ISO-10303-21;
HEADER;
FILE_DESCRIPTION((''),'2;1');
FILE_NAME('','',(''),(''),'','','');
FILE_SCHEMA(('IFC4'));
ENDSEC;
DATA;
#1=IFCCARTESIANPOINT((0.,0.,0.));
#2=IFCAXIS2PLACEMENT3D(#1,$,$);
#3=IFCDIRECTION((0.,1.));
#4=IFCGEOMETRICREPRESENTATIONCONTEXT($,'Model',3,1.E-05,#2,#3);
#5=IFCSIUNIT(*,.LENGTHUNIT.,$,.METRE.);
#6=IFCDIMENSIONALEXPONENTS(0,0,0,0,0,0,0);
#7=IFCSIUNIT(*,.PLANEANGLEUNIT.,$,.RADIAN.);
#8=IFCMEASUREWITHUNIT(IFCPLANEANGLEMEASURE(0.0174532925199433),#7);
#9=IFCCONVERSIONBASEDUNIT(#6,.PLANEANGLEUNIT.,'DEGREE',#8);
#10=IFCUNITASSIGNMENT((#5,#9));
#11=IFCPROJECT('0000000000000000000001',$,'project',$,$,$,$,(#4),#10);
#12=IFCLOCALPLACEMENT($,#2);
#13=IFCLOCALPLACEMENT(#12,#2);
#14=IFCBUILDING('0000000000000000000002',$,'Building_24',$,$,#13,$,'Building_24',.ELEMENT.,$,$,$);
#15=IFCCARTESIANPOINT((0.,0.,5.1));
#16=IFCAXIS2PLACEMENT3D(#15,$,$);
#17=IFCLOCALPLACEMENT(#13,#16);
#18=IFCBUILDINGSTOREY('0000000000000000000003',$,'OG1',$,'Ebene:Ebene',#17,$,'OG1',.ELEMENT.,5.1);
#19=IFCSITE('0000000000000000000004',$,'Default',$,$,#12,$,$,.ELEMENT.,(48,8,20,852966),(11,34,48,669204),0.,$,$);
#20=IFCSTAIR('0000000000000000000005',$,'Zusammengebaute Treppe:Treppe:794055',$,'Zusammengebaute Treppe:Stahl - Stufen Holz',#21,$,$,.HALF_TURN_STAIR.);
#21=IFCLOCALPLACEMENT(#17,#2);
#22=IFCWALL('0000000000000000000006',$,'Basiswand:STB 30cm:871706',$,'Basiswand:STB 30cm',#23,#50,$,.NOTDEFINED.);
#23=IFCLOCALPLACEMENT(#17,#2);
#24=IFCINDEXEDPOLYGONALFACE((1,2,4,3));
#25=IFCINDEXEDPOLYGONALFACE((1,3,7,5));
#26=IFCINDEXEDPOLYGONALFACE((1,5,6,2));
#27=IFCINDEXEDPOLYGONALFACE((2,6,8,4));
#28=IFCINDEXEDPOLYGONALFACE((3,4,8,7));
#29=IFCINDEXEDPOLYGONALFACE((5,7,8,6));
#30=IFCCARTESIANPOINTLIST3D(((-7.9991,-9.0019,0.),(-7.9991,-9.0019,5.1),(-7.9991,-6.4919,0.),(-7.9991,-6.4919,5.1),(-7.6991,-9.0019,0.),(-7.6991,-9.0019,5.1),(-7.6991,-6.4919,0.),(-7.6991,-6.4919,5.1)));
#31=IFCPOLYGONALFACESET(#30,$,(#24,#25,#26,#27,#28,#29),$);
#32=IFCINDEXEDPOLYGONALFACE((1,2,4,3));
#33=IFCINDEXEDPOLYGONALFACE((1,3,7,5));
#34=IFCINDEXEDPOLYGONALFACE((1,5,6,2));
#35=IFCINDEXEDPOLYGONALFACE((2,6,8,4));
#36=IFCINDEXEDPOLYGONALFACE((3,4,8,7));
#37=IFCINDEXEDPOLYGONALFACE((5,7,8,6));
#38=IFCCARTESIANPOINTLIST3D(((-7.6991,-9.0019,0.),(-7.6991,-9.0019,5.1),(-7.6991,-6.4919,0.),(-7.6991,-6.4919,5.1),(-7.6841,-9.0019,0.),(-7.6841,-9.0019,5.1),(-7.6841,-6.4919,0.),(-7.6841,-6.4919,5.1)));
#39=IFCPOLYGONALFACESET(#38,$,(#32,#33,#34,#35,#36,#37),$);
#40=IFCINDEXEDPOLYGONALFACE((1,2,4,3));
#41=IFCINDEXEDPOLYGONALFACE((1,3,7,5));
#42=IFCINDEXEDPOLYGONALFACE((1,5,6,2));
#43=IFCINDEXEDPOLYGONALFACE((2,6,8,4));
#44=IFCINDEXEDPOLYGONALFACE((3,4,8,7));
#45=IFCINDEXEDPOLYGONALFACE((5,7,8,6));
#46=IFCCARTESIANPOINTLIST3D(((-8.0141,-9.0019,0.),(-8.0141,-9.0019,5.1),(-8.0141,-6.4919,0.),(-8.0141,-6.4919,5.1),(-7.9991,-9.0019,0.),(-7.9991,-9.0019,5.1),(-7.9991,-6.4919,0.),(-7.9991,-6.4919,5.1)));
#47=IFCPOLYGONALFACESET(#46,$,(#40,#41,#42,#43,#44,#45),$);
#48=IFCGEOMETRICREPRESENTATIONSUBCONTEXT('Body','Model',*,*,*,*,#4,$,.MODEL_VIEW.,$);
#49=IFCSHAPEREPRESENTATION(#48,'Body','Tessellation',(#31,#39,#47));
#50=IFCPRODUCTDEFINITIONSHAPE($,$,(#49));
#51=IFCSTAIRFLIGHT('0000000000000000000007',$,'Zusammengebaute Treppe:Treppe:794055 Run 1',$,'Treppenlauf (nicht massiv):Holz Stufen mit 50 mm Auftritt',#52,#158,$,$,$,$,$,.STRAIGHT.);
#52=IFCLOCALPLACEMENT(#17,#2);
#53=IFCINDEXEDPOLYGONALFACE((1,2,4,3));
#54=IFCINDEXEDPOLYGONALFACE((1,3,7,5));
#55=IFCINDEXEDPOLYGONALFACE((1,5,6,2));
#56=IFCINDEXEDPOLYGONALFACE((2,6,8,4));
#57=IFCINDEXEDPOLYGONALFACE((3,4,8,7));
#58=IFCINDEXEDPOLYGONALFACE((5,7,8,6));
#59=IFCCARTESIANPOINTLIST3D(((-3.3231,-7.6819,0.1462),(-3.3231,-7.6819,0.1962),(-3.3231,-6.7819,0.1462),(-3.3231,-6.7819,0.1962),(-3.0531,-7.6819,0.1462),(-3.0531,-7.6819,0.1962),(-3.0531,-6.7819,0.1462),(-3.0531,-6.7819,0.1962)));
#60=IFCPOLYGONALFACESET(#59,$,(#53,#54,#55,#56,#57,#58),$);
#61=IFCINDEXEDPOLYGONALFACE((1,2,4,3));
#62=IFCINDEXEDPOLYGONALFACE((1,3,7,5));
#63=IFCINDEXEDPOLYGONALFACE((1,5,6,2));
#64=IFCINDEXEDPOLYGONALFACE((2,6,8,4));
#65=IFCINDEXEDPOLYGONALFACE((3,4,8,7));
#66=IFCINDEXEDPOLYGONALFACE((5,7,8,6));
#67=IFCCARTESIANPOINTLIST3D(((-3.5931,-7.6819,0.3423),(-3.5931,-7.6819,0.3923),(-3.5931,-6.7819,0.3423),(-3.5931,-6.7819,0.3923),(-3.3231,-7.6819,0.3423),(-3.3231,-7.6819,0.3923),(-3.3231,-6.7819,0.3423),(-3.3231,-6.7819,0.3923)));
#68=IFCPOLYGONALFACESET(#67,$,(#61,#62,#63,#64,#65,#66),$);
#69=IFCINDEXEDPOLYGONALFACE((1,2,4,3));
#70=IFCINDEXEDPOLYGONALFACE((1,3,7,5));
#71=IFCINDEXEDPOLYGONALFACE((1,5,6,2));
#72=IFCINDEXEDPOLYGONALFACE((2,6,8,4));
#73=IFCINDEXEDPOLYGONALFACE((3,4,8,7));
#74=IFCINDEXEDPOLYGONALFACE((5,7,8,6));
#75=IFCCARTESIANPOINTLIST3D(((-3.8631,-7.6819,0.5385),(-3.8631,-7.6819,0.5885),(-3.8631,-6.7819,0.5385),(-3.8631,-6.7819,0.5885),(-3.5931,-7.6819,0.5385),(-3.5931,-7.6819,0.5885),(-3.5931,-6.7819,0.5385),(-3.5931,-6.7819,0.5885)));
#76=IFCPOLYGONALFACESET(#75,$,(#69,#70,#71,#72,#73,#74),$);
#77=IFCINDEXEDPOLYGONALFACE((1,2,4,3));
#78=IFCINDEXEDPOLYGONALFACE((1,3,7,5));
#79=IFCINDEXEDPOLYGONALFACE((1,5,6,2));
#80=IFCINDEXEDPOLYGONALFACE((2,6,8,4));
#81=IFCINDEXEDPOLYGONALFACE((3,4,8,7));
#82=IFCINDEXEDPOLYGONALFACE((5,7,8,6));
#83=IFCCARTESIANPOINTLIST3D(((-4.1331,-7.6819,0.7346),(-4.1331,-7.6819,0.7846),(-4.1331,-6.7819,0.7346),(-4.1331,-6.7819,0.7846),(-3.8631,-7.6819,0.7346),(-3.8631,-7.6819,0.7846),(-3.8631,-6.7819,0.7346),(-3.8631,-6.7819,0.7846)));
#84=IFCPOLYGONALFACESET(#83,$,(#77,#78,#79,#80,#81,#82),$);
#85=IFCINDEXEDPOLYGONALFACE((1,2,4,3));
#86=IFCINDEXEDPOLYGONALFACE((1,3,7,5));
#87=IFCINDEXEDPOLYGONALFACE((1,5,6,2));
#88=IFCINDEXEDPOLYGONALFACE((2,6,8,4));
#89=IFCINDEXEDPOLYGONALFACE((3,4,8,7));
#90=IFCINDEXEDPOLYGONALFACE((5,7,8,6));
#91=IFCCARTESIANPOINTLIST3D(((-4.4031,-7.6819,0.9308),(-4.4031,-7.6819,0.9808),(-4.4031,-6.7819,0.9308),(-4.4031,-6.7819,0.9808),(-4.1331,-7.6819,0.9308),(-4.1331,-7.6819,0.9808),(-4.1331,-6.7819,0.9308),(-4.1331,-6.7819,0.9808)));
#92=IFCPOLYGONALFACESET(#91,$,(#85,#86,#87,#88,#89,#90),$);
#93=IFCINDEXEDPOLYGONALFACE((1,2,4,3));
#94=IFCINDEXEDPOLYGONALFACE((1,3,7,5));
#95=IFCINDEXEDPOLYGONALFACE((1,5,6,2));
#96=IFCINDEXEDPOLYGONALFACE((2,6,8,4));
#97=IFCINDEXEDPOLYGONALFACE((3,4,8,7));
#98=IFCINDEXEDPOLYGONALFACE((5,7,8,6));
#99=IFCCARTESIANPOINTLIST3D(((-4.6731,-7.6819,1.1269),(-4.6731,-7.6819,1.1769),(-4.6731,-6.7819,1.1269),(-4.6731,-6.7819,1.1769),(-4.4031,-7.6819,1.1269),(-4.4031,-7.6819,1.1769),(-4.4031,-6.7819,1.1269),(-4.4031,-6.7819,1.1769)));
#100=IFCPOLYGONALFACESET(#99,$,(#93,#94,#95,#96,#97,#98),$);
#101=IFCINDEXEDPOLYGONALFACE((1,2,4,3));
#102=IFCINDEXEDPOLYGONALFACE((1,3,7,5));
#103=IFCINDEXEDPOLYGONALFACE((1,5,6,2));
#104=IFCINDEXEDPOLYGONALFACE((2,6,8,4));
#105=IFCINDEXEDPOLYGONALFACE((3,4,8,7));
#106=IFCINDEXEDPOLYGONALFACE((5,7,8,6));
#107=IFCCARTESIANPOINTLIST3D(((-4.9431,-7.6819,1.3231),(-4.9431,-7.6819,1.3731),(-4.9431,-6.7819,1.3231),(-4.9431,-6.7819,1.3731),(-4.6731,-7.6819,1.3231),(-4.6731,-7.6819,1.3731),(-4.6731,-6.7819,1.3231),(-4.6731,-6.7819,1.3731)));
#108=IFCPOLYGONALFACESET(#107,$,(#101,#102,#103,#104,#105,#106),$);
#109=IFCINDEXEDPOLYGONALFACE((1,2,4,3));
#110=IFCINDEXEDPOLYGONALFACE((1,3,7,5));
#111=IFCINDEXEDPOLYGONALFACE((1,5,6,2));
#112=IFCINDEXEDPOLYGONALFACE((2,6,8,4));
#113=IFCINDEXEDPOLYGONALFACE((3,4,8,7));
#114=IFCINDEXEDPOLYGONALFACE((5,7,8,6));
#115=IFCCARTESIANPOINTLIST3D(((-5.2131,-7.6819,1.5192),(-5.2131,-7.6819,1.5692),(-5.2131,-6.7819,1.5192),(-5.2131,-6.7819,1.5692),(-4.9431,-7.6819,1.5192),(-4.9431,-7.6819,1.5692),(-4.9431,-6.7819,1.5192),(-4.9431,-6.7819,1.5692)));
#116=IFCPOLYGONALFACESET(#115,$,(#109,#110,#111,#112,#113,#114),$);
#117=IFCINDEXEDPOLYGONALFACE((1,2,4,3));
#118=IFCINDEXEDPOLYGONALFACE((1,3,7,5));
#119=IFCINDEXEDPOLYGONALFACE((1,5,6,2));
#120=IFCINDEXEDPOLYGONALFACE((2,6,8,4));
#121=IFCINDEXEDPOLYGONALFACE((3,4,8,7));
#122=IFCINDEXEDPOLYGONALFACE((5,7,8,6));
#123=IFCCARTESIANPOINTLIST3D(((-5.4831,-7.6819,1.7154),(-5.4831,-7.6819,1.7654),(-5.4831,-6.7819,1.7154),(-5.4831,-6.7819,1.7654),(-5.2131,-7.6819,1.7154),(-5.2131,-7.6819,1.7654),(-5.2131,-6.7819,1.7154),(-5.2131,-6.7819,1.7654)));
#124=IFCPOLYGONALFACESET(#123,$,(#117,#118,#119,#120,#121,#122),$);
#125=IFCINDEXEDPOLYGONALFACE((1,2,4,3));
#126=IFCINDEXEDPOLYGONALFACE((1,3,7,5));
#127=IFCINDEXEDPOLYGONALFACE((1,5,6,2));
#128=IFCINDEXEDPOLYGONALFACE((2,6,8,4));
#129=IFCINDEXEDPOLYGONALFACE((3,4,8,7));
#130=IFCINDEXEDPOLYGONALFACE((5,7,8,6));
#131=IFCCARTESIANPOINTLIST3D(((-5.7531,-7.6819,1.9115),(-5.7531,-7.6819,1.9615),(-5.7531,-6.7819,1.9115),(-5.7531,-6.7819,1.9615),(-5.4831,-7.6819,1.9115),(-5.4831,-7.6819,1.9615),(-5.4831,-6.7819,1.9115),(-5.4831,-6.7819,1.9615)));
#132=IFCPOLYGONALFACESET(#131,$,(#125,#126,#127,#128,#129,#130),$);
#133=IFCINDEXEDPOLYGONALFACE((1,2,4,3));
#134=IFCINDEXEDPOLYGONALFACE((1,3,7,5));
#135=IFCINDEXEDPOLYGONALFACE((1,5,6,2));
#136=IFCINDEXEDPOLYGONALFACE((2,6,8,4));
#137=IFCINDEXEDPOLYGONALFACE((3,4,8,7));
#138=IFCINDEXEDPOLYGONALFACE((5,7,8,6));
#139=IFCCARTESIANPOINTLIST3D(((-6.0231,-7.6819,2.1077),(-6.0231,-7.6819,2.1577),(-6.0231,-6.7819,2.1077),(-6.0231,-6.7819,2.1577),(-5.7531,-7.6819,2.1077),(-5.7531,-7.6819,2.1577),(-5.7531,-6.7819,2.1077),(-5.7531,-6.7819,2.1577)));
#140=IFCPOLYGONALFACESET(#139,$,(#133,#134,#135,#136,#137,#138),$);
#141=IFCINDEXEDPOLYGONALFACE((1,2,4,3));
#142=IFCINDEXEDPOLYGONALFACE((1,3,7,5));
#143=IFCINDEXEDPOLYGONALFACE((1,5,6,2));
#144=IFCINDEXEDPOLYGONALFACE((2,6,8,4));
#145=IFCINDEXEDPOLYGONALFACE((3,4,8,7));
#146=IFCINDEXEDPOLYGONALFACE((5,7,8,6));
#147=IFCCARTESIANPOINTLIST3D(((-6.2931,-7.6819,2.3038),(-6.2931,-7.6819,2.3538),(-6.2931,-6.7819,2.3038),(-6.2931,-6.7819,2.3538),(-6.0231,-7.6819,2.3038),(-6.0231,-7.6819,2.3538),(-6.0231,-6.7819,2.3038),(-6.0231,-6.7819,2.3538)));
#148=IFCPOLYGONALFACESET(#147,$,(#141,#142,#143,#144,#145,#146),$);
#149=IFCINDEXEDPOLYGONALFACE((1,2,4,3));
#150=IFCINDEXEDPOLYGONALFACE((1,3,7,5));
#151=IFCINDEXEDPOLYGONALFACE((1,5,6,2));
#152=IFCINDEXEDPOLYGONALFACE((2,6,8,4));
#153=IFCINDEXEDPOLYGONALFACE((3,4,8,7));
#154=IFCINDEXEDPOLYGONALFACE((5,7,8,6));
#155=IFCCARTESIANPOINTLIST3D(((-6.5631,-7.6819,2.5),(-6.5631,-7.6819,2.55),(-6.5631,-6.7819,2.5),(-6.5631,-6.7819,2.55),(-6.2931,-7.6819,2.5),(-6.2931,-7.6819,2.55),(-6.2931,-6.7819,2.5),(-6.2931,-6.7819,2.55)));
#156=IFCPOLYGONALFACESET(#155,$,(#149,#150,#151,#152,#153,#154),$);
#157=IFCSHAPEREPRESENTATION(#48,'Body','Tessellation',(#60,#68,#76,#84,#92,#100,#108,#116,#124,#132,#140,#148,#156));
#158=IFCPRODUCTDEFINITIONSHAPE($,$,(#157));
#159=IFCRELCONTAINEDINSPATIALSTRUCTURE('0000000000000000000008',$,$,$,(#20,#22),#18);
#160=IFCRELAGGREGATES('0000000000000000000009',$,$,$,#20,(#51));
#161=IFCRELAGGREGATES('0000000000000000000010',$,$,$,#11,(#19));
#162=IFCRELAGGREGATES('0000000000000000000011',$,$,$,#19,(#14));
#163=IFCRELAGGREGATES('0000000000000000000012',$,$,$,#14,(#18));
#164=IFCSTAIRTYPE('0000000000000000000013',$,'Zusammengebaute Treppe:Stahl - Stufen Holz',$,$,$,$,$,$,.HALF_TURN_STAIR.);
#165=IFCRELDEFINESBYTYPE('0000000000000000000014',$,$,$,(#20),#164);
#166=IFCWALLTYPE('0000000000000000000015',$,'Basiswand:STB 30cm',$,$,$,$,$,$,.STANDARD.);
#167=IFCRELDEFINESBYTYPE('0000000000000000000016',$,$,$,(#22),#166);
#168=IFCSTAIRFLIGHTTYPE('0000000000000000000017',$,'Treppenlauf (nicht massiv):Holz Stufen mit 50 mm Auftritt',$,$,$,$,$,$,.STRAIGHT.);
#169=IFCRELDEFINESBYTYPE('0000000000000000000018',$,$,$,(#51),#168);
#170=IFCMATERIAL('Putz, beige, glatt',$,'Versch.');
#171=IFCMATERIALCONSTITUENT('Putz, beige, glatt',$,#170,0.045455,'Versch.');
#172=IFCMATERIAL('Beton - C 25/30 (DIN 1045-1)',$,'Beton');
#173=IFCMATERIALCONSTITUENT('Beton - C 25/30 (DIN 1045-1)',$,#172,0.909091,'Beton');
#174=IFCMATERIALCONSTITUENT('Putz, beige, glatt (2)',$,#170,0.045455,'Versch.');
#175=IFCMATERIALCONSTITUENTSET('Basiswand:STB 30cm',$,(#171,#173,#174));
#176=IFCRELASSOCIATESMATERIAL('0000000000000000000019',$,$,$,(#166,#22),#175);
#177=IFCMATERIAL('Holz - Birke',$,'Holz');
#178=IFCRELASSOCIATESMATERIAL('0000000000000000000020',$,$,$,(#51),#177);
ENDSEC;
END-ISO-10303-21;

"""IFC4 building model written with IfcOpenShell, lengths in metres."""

from ifc_helpers import new_model, entity, si_unit, converted_unit, direction, frame, origin, place, context, subcontext, project, spatial, indexed_curve, outline, extrude, material, constituent, constituent_set, type_object, element, aggregate, save


model = new_model("IFC4")

# Units and contexts
model_context = context("Model", 3, precision=1e-05, world=origin(), true_north=direction((0.0, 1.0)))
body_context = subcontext(model_context, "Body", "Model", "MODEL_VIEW")
ifc_project = project(units=[si_unit("LENGTHUNIT", "METRE"), converted_unit("PLANEANGLEUNIT", "DEGREE", entity("IfcPlaneAngleMeasure", 0.0174532925199433), si_unit("PLANEANGLEUNIT", "RADIAN"), dimensions=[0, 0, 0, 0, 0, 0, 0])], contexts=[model_context])

# Site, building, storey
site_placement = place(None, origin())
site = spatial("IfcSite", under=ifc_project, at=site_placement, Name="Default", CompositionType="ELEMENT", RefLatitude=(48, 8, 20, 852966), RefLongitude=(11, 34, 48, 669204), RefElevation=0.0)
building_placement = place(site_placement, origin())
building = spatial("IfcBuilding", under=site, at=building_placement, Name="Building_24", LongName="Building_24", CompositionType="ELEMENT")
storey_placement = place(building_placement, frame((0.0, 0.0, 5.1)))
storey = spatial("IfcBuildingStorey", under=building, at=storey_placement, Name="OG1", ObjectType="Ebene:Ebene", LongName="OG1", CompositionType="ELEMENT", Elevation=5.1)

# Stair
stair_type = type_object("IfcStairType", Name="Zusammengebaute Treppe:Stahl - Stufen Holz", PredefinedType="HALF_TURN_STAIR")
stair_placement = place(storey_placement, origin())
stair = element("IfcStair", 1, at=stair_placement, inside=storey, type_object=stair_type, Name="Zusammengebaute Treppe:Treppe:794055", ObjectType="Zusammengebaute Treppe:Stahl - Stufen Holz", PredefinedType="HALF_TURN_STAIR")
ifc_material_1 = material(Name="Holz - Birke", Category="Holz")

# Shared definitions
ifc_material_2 = material(Name="Putz, beige, glatt", Category="Versch.")
ifc_material_3 = material(Name="Beton - C 25/30 (DIN 1045-1)", Category="Beton")

# Wall
ifc_constituent_1 = constituent(ifc_material_2, Name="Putz, beige, glatt", Category="Versch.", fraction=0.045455)
ifc_constituent_2 = constituent(ifc_material_3, Name="Beton - C 25/30 (DIN 1045-1)", Category="Beton", fraction=0.909091)
ifc_constituent_3 = constituent(ifc_material_2, Name="Putz, beige, glatt (2)", Category="Versch.", fraction=0.045455)
ifc_constituent_set_1 = constituent_set(constituents=[ifc_constituent_1, ifc_constituent_2, ifc_constituent_3], Name="Basiswand:STB 30cm")
wall_type_1 = type_object("IfcWallType", Name="Basiswand:STB 30cm", PredefinedType="STANDARD", material=ifc_constituent_set_1)
wall_1_placement = place(storey_placement, frame((-7.8491, -6.4919, 0.0), z_axis=(0.0, 0.0, 1.0), x_axis=(0.0, -1.0, 0.0)))
element("IfcWall", 2, at=wall_1_placement, inside=storey, type_object=wall_type_1, material=ifc_constituent_set_1, Name="Basiswand:STB 30cm:871706", ObjectType="Basiswand:STB 30cm", PredefinedType="NOTDEFINED", context=body_context, shape_type="SweptSolid", body=[
    extrude(outline(indexed_curve([(-1.255, -0.15), (1.255, -0.15), (1.255, 0.15), (-1.255, 0.15), (-1.255, -0.15)], self_intersect=False)), frame((1.255, 0.0, 0.0)), (0.0, 0.0, 1.0), 5.1),
    extrude(outline(indexed_curve([(-0.0075, -1.255), (0.0075, -1.255), (0.0075, 1.255), (-0.0075, 1.255), (-0.0075, -1.255)], self_intersect=False)), frame((1.255, 0.1575, 0.0), z_axis=(0.0, 0.0, 1.0), x_axis=(0.0, -1.0, 0.0)), (0.0, 0.0, 1.0), 5.1),
    extrude(outline(indexed_curve([(-0.0075, -1.255), (0.0075, -1.255), (0.0075, 1.255), (-0.0075, 1.255), (-0.0075, -1.255)], self_intersect=False)), frame((1.255, -0.1575, 0.0), z_axis=(0.0, 0.0, 1.0), x_axis=(0.0, 1.0, 0.0)), (0.0, 0.0, 1.0), 5.1),
])

# Stair flight
stair_flight_type = type_object("IfcStairFlightType", Name="Treppenlauf (nicht massiv):Holz Stufen mit 50 mm Auftritt", PredefinedType="STRAIGHT")
stair_flight_1_placement = place(stair_placement, origin())
stair_flight_1 = element("IfcStairFlight", 3, at=stair_flight_1_placement, type_object=stair_flight_type, material=ifc_material_1, Name="Zusammengebaute Treppe:Treppe:794055 Run 1", ObjectType="Treppenlauf (nicht massiv):Holz Stufen mit 50 mm Auftritt", PredefinedType="STRAIGHT", context=body_context, shape_type="SweptSolid", body=[
    extrude(outline(indexed_curve([(-0.135, -0.45), (0.135, -0.45), (0.135, 0.45), (-0.135, 0.45), (-0.135, -0.45)], self_intersect=False)), frame((-3.1881, -7.2319, 0.1462)), (0.0, 0.0, 1.0), 0.05),
    extrude(outline(indexed_curve([(-0.135, -0.45), (0.135, -0.45), (0.135, 0.45), (-0.135, 0.45), (-0.135, -0.45)], self_intersect=False)), frame((-3.4581, -7.2319, 0.3423)), (0.0, 0.0, 1.0), 0.05),
    extrude(outline(indexed_curve([(-0.135, -0.45), (0.135, -0.45), (0.135, 0.45), (-0.135, 0.45), (-0.135, -0.45)], self_intersect=False)), frame((-3.7281, -7.2319, 0.5385)), (0.0, 0.0, 1.0), 0.05),
    extrude(outline(indexed_curve([(-0.135, -0.45), (0.135, -0.45), (0.135, 0.45), (-0.135, 0.45), (-0.135, -0.45)], self_intersect=False)), frame((-3.9981, -7.2319, 0.7346)), (0.0, 0.0, 1.0), 0.05),
    extrude(outline(indexed_curve([(-0.135, -0.45), (0.135, -0.45), (0.135, 0.45), (-0.135, 0.45), (-0.135, -0.45)], self_intersect=False)), frame((-4.2681, -7.2319, 0.9308)), (0.0, 0.0, 1.0), 0.05),
    extrude(outline(indexed_curve([(-0.135, -0.45), (0.135, -0.45), (0.135, 0.45), (-0.135, 0.45), (-0.135, -0.45)], self_intersect=False)), frame((-4.5381, -7.2319, 1.1269)), (0.0, 0.0, 1.0), 0.05),
    extrude(outline(indexed_curve([(-0.135, -0.45), (0.135, -0.45), (0.135, 0.45), (-0.135, 0.45), (-0.135, -0.45)], self_intersect=False)), frame((-4.8081, -7.2319, 1.3231)), (0.0, 0.0, 1.0), 0.05),
    extrude(outline(indexed_curve([(-0.135, -0.45), (0.135, -0.45), (0.135, 0.45), (-0.135, 0.45), (-0.135, -0.45)], self_intersect=False)), frame((-5.0781, -7.2319, 1.5192)), (0.0, 0.0, 1.0), 0.05),
    extrude(outline(indexed_curve([(-0.135, -0.45), (0.135, -0.45), (0.135, 0.45), (-0.135, 0.45), (-0.135, -0.45)], self_intersect=False)), frame((-5.3481, -7.2319, 1.7154)), (0.0, 0.0, 1.0), 0.05),
    extrude(outline(indexed_curve([(-0.135, -0.45), (0.135, -0.45), (0.135, 0.45), (-0.135, 0.45), (-0.135, -0.45)], self_intersect=False)), frame((-5.6181, -7.2319, 1.9115)), (0.0, 0.0, 1.0), 0.05),
    extrude(outline(indexed_curve([(-0.135, -0.45), (0.135, -0.45), (0.135, 0.45), (-0.135, 0.45), (-0.135, -0.45)], self_intersect=False)), frame((-5.8881, -7.2319, 2.1077)), (0.0, 0.0, 1.0), 0.05),
    extrude(outline(indexed_curve([(-0.135, -0.45), (0.135, -0.45), (0.135, 0.45), (-0.135, 0.45), (-0.135, -0.45)], self_intersect=False)), frame((-6.1581, -7.2319, 2.3038)), (0.0, 0.0, 1.0), 0.05),
    extrude(outline(indexed_curve([(-0.135, -0.45), (0.135, -0.45), (0.135, 0.45), (-0.135, 0.45), (-0.135, -0.45)], self_intersect=False)), frame((-6.4281, -7.2319, 2.5)), (0.0, 0.0, 1.0), 0.05),
])
aggregate(stair, [stair_flight_1])

save(model, "model.ifc")
